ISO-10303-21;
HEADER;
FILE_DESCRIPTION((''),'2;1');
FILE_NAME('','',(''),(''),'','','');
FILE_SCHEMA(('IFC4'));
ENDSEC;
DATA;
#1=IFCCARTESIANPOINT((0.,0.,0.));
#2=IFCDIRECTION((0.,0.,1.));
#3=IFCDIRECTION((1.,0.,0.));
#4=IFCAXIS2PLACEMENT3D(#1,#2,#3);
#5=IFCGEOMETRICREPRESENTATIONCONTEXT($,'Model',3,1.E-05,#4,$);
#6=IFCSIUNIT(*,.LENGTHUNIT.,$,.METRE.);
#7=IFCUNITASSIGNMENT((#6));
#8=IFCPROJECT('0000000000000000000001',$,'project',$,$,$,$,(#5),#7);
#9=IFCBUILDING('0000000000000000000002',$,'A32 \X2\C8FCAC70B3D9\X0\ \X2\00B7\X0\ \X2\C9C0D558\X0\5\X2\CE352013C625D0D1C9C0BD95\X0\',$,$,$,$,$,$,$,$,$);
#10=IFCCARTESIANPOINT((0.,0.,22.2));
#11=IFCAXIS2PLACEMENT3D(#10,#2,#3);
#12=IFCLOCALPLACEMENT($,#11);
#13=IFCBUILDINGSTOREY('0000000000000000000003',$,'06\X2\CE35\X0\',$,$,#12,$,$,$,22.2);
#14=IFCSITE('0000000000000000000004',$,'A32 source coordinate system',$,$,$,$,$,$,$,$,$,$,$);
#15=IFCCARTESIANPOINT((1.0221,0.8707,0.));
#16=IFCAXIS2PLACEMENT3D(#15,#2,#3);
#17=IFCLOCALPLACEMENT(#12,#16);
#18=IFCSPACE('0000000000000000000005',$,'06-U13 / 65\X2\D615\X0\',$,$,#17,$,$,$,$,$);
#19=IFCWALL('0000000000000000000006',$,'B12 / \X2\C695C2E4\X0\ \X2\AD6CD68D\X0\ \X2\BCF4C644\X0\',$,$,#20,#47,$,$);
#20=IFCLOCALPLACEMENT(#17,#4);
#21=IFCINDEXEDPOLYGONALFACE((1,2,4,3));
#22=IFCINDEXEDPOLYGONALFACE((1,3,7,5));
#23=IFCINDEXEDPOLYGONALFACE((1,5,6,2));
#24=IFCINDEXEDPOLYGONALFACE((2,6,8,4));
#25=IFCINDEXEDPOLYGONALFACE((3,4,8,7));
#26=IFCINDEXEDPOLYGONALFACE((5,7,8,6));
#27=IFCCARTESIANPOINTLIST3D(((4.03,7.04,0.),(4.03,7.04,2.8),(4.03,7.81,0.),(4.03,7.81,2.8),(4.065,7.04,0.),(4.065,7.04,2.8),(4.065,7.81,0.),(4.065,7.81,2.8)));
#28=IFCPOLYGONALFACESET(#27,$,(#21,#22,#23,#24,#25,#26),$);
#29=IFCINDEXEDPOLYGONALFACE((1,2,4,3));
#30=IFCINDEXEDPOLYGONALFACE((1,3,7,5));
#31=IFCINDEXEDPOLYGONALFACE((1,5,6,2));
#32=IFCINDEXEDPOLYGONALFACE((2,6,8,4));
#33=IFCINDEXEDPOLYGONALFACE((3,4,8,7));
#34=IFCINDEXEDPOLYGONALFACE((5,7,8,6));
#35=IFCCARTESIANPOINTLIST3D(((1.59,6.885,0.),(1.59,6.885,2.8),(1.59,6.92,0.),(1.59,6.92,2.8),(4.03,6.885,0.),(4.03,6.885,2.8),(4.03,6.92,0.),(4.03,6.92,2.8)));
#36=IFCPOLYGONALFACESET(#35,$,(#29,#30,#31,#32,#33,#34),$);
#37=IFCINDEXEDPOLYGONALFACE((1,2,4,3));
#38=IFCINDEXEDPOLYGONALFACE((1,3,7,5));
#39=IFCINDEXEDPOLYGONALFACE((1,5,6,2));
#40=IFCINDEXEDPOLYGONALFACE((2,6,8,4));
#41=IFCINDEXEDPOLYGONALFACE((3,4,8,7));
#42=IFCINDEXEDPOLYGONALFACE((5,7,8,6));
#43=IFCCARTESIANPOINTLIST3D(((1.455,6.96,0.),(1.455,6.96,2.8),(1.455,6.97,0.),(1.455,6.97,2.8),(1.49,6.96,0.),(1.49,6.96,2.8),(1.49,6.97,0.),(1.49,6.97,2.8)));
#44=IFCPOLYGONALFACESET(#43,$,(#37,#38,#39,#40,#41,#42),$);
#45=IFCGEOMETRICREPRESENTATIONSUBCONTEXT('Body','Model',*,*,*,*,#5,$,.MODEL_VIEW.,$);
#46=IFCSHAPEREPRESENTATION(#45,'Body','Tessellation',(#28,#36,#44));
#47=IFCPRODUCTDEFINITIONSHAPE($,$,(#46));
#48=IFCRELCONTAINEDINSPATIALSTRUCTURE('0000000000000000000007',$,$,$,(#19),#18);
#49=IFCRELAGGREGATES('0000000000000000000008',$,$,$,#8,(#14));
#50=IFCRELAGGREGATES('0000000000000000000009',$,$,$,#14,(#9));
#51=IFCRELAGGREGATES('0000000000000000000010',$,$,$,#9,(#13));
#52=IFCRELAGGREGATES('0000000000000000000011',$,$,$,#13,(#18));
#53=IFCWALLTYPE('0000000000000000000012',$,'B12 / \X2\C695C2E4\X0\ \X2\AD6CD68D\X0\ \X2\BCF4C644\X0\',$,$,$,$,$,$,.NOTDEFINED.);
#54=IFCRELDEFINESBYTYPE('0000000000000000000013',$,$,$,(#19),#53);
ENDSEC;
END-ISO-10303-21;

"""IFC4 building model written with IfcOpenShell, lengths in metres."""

from ifc_helpers import new_model, si_unit, frame, origin, origin_with_axes, place, context, subcontext, project, spatial, polyline, outline, extrude, source, transform, mapped, type_object, type_shapes, element, save


model = new_model("IFC4")

# Units and contexts
model_context = context("Model", 3, precision=1e-05, world=origin_with_axes())
body_context = subcontext(model_context, "Body", "Model", "MODEL_VIEW")
ifc_project = project(units=[si_unit("LENGTHUNIT", "METRE")], contexts=[model_context])

# Site, building, storey, space
storey_placement = place(None, frame((0.0, 0.0, 22.2), z_axis=(0.0, 0.0, 1.0), x_axis=(1.0, 0.0, 0.0)))
space_placement = place(storey_placement, frame((1.0221, 0.8707, 0.0), z_axis=(0.0, 0.0, 1.0), x_axis=(1.0, 0.0, 0.0)))
site = spatial("IfcSite", under=ifc_project, Name="A32 source coordinate system")
building = spatial("IfcBuilding", under=site, Name="A32 주거동 · 지하5층–옥탑지붕")
storey = spatial("IfcBuildingStorey", under=building, at=storey_placement, Name="06층", Elevation=22.2)
space = spatial("IfcSpace", under=storey, at=space_placement, Name="06-U13 / 65형")

# Wall
wall_type_1 = type_object("IfcWallType", Name="B12 / 욕실 구획 보완", PredefinedType="NOTDEFINED")
shared_shape_1 = source(origin(), body_context, "Body", "SweptSolid", [
    extrude(outline(polyline([(4.065, 7.04), (4.03, 7.04), (4.03, 7.81), (4.065, 7.81), (4.065, 7.04)])), origin(), (0.0, 0.0, 1.0), 2.8),
    extrude(outline(polyline([(1.59, 6.92), (4.03, 6.92), (4.03, 6.885), (1.59, 6.885), (1.59, 6.92)])), origin(), (0.0, 0.0, 1.0), 2.8),
    extrude(outline(polyline([(1.455, 6.97), (1.49, 6.97), (1.49, 6.96), (1.455, 6.96), (1.455, 6.97)])), origin(), (0.0, 0.0, 1.0), 2.8),
])
type_shapes(wall_type_1, [shared_shape_1])
wall_1_placement = place(space_placement, origin_with_axes())
element("IfcWall", 1, at=wall_1_placement, inside=space, type_object=wall_type_1, Name="B12 / 욕실 구획 보완", context=body_context, shape_type="MappedRepresentation", body=[
    mapped(shared_shape_1, transform((0.0, 0.0, 0.0), scale=1.0)),
])

save(model, "model.ifc")
